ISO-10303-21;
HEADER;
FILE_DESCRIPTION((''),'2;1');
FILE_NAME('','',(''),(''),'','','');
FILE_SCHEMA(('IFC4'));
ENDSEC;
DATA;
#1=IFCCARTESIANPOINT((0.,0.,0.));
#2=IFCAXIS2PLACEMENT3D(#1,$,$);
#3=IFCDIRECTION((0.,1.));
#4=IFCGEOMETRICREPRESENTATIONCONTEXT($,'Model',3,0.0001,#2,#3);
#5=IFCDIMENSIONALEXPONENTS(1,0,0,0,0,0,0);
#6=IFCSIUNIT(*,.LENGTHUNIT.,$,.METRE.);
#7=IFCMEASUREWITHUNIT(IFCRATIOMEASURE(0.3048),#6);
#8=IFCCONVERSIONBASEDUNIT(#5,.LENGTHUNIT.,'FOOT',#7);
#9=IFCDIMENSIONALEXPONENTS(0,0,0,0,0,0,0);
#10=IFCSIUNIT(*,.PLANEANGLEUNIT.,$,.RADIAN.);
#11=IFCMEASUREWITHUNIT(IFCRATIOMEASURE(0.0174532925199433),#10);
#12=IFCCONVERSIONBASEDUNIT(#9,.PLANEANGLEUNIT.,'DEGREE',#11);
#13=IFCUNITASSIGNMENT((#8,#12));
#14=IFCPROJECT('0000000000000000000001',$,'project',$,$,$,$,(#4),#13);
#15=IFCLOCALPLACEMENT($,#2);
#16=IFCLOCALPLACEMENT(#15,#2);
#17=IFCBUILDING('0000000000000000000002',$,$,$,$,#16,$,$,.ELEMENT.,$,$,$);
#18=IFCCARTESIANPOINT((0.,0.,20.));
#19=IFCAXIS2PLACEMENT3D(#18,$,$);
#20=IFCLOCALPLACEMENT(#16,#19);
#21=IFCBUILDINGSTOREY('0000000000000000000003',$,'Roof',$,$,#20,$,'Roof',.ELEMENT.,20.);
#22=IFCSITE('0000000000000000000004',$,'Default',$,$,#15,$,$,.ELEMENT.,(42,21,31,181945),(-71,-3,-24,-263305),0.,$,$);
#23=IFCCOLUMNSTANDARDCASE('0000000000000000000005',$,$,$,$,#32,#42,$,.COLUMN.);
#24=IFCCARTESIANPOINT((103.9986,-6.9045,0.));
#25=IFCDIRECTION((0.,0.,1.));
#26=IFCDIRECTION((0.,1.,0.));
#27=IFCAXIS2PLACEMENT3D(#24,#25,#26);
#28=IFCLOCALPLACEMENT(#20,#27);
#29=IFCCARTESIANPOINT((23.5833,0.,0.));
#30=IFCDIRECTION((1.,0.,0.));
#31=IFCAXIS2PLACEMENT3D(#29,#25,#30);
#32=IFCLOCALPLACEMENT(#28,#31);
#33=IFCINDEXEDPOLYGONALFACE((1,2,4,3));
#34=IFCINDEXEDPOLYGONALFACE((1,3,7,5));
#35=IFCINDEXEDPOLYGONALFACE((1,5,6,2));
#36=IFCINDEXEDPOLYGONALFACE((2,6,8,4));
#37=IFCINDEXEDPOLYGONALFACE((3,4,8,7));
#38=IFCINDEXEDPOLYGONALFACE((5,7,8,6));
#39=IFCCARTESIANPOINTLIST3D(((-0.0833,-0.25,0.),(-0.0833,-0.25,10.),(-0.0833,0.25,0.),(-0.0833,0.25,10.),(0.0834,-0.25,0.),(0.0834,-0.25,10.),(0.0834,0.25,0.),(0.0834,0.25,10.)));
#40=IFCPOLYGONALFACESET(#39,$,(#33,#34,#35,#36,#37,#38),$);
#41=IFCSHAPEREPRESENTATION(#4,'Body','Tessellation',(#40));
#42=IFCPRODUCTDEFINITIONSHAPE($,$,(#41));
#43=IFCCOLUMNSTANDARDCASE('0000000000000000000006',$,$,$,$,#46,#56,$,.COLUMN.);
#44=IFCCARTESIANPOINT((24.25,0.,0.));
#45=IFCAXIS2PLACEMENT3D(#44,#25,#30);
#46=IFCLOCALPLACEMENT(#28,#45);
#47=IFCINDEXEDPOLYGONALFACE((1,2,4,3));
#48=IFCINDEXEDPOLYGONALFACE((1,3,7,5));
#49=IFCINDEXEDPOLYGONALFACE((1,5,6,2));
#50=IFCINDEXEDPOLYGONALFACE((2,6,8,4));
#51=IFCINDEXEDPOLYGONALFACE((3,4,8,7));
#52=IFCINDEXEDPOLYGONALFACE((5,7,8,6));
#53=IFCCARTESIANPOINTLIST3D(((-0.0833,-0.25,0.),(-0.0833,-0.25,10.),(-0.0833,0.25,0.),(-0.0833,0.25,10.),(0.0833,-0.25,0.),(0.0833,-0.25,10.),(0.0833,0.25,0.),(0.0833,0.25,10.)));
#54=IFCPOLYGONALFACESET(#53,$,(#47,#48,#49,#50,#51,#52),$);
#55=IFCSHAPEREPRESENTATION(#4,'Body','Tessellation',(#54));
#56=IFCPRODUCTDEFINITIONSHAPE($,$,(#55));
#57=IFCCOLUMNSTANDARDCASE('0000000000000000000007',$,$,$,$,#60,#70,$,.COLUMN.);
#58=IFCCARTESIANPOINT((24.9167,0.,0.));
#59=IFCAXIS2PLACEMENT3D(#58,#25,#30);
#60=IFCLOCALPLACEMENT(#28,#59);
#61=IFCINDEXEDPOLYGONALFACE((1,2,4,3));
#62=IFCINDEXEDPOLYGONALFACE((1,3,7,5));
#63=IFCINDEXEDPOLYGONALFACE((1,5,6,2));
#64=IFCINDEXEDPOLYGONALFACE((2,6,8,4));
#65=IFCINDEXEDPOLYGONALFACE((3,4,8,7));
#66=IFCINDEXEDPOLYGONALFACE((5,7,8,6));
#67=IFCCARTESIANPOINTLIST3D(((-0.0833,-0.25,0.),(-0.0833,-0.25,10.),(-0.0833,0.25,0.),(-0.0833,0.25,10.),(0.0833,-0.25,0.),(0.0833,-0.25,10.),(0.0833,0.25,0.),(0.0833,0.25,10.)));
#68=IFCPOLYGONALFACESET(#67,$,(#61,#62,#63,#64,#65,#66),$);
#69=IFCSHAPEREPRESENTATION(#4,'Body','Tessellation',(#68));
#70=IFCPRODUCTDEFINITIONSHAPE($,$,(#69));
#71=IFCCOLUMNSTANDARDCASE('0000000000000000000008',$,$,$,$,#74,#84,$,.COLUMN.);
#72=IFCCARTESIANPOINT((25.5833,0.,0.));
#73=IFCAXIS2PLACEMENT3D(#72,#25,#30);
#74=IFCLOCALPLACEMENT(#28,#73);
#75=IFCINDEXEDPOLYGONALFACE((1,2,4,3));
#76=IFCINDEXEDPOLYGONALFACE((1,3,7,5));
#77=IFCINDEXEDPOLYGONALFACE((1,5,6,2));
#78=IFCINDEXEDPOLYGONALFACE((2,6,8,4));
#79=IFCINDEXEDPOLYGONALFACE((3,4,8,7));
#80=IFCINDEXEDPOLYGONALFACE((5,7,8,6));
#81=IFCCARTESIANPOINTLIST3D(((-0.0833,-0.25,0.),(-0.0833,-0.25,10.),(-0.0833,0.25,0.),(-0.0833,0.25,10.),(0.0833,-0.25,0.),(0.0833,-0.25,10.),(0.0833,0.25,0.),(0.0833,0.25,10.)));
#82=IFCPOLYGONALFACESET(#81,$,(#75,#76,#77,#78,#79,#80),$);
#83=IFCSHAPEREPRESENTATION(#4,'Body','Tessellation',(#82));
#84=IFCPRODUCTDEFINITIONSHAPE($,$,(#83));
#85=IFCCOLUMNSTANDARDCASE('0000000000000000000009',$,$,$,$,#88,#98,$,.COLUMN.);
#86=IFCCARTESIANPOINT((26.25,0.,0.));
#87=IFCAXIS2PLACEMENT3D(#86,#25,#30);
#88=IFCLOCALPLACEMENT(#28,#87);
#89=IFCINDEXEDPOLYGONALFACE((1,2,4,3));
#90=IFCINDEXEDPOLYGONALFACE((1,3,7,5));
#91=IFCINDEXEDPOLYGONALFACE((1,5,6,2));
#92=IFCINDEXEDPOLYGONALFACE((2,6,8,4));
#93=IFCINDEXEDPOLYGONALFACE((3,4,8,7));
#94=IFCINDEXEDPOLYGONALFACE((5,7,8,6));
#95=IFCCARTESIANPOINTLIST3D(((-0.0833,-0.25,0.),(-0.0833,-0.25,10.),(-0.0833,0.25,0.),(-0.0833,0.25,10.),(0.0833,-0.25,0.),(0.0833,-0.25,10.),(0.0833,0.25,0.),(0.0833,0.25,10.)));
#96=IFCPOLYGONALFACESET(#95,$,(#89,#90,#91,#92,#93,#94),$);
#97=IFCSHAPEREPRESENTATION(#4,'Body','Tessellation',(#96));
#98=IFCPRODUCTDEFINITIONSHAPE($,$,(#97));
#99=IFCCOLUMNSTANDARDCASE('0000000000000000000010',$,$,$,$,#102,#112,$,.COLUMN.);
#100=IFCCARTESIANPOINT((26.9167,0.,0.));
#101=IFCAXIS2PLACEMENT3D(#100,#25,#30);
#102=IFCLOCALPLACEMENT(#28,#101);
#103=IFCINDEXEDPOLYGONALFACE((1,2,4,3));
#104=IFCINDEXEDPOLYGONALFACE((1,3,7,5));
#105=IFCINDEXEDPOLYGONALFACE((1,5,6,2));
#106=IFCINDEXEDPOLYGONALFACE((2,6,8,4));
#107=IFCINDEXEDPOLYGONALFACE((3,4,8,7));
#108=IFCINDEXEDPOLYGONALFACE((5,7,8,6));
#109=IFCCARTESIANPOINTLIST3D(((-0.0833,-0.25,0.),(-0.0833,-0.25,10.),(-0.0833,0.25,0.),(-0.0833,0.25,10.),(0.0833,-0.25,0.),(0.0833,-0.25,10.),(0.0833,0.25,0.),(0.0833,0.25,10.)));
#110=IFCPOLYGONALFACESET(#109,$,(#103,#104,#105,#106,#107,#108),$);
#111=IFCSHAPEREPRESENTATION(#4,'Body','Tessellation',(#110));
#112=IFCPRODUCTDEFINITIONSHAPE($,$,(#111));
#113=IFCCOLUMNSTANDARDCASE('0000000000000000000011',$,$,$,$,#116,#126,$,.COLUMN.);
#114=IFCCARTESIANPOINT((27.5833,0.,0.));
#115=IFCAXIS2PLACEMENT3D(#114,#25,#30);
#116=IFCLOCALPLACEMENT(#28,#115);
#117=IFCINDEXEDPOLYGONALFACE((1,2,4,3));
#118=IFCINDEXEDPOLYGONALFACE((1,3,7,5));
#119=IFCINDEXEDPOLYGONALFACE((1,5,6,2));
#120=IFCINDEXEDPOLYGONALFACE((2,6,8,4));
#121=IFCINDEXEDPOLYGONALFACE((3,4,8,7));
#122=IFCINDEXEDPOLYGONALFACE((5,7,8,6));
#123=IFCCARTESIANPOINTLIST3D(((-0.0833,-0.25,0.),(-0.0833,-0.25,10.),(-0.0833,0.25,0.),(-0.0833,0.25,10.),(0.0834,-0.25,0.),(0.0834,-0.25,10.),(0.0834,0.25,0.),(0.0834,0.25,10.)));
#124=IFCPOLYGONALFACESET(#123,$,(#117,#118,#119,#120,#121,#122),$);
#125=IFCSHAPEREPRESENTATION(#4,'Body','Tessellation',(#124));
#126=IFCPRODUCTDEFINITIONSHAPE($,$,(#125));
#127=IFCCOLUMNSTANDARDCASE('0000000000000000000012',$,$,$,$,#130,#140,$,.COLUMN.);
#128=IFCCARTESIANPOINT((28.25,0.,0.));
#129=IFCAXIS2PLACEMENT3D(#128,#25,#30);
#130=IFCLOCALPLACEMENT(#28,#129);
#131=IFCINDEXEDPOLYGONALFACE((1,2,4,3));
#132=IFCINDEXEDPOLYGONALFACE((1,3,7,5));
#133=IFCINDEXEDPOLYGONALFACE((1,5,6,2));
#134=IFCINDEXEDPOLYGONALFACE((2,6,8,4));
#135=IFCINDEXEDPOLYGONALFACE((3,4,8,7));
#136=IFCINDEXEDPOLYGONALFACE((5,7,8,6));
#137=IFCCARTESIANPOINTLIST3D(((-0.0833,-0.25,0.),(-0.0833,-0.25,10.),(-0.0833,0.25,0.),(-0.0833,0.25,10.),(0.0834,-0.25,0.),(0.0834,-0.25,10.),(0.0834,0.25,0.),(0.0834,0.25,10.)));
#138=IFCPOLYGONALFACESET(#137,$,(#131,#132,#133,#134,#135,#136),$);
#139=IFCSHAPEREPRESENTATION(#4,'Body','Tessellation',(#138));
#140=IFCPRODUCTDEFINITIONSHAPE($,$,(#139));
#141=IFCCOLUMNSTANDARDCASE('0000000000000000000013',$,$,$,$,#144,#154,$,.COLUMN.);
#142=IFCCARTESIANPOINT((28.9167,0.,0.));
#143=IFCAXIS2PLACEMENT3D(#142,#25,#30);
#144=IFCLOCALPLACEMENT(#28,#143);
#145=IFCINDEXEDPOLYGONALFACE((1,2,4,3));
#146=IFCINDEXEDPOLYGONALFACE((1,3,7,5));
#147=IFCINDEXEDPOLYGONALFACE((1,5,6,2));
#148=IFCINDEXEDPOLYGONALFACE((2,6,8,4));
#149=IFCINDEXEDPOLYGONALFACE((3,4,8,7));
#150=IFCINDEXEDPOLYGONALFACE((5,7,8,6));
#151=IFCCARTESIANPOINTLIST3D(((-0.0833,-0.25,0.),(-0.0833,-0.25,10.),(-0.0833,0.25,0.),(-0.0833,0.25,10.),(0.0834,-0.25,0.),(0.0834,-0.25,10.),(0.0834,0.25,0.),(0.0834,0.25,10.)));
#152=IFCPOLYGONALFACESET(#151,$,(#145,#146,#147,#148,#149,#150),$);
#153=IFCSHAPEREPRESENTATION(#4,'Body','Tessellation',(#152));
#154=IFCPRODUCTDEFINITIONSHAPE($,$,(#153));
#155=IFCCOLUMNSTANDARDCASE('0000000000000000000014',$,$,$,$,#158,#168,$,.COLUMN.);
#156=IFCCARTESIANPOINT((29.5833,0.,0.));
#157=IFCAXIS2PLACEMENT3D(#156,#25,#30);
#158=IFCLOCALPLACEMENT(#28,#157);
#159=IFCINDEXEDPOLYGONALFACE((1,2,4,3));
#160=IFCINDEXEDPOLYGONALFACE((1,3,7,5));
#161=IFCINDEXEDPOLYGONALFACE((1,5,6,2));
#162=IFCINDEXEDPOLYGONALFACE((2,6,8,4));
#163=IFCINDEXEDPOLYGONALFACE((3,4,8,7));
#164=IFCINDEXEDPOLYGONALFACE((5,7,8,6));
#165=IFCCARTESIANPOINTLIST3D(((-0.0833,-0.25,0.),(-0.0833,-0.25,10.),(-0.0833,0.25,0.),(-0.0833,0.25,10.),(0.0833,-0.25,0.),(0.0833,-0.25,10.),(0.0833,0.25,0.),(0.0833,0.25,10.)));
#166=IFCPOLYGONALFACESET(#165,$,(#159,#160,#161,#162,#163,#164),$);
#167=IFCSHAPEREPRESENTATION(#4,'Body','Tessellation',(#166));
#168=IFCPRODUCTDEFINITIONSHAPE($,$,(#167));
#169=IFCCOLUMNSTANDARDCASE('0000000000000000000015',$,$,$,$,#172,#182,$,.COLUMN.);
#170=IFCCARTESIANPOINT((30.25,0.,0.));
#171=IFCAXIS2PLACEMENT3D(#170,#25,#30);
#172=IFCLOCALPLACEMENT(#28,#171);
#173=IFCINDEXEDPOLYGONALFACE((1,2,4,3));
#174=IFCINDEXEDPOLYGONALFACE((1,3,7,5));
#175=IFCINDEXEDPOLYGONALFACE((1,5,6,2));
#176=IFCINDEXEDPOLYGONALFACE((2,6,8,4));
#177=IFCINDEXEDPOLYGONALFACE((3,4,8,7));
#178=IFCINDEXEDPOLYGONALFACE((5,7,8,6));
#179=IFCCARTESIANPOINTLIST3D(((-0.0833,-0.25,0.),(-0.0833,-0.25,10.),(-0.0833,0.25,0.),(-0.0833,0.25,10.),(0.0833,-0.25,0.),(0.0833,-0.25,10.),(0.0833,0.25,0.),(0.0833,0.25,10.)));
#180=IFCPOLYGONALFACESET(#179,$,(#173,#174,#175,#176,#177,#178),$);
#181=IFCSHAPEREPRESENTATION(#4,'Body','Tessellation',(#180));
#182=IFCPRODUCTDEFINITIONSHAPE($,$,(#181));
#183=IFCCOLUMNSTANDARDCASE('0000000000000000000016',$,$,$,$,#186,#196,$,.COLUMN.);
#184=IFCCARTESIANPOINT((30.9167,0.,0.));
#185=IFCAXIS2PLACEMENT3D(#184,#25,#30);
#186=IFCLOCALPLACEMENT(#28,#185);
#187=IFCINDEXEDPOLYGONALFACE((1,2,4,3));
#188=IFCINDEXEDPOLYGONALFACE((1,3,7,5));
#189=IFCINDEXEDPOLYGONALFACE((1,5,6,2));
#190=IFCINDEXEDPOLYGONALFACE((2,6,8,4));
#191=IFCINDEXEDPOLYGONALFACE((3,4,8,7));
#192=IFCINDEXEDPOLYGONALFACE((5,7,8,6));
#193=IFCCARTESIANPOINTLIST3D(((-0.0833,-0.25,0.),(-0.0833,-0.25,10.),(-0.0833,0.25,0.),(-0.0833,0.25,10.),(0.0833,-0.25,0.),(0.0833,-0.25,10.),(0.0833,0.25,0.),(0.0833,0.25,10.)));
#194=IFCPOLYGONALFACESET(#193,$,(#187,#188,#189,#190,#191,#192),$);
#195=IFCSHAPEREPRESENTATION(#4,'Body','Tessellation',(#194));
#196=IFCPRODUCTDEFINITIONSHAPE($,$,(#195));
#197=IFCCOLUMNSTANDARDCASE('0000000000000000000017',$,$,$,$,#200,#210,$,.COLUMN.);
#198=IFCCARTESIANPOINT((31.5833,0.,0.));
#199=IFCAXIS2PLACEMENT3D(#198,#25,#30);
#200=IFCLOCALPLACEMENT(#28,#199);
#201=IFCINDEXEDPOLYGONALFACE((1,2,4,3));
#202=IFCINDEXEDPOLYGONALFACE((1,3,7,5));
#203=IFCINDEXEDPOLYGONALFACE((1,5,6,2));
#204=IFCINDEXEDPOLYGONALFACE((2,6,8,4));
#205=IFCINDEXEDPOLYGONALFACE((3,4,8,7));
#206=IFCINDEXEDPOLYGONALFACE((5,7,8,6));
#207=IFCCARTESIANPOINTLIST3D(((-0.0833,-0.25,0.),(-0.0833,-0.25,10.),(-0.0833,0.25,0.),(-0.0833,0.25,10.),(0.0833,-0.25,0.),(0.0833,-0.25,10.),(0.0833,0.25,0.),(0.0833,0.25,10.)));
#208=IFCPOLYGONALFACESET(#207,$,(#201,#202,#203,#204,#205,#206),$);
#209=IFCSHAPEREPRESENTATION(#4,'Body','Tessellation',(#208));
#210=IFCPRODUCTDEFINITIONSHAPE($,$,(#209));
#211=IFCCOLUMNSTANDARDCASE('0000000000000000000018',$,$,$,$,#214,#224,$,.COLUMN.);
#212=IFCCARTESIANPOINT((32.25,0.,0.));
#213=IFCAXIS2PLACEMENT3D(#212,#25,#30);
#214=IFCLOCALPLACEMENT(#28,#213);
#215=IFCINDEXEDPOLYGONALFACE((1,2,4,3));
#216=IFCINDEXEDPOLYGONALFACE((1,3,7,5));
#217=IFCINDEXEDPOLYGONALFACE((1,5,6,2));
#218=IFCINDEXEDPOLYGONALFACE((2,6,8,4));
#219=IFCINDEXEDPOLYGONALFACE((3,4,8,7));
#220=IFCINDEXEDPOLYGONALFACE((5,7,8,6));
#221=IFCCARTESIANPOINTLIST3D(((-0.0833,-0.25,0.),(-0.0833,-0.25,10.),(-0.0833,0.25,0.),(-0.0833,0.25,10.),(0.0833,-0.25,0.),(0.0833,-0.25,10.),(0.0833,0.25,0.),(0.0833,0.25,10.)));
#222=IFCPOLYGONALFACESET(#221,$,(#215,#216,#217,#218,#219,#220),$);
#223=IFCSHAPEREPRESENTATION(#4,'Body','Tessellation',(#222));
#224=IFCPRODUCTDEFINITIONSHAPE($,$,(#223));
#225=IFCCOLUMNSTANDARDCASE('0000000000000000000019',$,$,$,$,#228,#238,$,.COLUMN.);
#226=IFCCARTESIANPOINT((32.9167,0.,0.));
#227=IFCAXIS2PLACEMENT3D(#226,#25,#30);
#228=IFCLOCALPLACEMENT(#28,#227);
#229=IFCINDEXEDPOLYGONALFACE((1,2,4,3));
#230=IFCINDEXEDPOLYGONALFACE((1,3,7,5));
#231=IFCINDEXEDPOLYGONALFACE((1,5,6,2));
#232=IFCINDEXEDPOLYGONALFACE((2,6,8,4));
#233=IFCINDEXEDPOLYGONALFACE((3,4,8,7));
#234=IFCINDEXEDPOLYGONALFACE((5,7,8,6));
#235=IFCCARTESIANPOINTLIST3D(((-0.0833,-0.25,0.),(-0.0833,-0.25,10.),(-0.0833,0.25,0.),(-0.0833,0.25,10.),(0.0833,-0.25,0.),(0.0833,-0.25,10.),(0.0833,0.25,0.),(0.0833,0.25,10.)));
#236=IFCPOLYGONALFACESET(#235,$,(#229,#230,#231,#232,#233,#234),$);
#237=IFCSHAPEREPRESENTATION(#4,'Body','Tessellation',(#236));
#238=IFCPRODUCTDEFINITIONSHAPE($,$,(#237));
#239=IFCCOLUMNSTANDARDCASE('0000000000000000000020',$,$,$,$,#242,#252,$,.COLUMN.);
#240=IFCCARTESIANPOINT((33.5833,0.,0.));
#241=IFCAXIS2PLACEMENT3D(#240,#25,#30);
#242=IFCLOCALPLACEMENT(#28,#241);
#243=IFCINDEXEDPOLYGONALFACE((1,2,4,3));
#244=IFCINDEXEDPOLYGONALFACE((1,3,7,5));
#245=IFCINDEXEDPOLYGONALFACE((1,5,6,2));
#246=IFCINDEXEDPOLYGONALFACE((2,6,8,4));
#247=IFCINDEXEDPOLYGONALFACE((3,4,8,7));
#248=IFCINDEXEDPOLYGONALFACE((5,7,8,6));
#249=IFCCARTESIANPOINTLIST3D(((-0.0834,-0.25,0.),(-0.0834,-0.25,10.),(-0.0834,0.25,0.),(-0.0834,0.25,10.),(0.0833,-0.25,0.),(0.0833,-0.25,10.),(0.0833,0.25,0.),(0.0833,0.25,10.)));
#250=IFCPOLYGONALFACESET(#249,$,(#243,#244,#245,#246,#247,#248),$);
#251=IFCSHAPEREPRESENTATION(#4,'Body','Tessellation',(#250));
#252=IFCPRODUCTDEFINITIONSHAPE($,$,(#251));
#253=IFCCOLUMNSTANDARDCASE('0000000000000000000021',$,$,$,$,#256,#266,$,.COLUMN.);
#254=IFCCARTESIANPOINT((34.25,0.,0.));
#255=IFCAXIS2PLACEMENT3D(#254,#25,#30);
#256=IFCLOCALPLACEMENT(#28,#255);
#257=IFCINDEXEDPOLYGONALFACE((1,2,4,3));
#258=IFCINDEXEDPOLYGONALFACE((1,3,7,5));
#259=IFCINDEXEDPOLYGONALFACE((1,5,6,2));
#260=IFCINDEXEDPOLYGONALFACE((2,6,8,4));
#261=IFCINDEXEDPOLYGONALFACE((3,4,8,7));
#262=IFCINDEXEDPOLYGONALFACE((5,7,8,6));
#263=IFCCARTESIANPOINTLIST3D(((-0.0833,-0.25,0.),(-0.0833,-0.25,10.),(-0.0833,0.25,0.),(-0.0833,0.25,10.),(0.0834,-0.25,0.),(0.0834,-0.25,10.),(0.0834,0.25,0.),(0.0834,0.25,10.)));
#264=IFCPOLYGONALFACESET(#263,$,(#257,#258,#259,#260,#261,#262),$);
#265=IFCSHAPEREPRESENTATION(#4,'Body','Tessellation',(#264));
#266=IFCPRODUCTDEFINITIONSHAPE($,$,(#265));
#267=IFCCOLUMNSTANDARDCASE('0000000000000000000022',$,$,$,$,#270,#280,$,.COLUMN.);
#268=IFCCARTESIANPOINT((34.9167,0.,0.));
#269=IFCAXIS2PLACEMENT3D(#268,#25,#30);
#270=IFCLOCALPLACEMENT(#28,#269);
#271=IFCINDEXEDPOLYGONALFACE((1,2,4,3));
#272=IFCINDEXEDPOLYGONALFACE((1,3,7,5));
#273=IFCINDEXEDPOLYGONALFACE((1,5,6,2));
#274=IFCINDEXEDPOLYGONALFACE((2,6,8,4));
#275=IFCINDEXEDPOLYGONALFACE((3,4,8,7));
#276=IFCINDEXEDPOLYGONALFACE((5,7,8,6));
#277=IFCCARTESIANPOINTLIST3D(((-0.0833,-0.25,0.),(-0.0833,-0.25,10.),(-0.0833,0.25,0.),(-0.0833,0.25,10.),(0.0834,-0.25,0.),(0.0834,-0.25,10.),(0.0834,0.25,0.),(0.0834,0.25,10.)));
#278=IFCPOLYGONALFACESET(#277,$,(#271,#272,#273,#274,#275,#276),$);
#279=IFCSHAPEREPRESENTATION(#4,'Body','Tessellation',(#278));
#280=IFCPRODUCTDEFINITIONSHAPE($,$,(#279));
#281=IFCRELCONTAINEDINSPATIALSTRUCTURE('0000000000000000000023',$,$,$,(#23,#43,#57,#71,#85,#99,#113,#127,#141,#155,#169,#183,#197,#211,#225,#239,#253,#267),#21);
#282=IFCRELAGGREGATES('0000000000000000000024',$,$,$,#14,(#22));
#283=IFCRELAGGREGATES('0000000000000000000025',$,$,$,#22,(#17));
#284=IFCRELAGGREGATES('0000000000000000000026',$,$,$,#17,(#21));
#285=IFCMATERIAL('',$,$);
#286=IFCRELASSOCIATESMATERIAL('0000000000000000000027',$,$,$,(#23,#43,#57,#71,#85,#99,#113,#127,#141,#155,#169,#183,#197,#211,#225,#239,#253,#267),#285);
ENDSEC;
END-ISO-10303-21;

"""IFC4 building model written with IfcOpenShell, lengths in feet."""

from ifc_helpers import new_model, entity, si_unit, converted_unit, direction, frame, origin, place, context, project, spatial, rectangle, extrude, material, element, save


model = new_model("IFC4")

# Units and contexts
model_context = context("Model", 3, precision=0.0001, world=origin(), true_north=direction((0.0, 1.0)))
ifc_project = project(units=[converted_unit("LENGTHUNIT", "FOOT", entity("IfcRatioMeasure", 0.3048), si_unit("LENGTHUNIT", "METRE"), dimensions=[1, 0, 0, 0, 0, 0, 0]), converted_unit("PLANEANGLEUNIT", "DEGREE", entity("IfcRatioMeasure", 0.0174532925199433), si_unit("PLANEANGLEUNIT", "RADIAN"), dimensions=[0, 0, 0, 0, 0, 0, 0])], contexts=[model_context])

# Site, building, storey
site_placement = place(None, origin())
site = spatial("IfcSite", under=ifc_project, at=site_placement, Name="Default", CompositionType="ELEMENT", RefLatitude=(42, 21, 31, 181945), RefLongitude=(-71, -3, -24, -263305), RefElevation=0.0)
building_placement = place(site_placement, origin())
building = spatial("IfcBuilding", under=site, at=building_placement, CompositionType="ELEMENT")
storey_placement = place(building_placement, frame((0.0, 0.0, 20.0)))
storey = spatial("IfcBuildingStorey", under=building, at=storey_placement, Name="Roof", LongName="Roof", CompositionType="ELEMENT", Elevation=20.0)

# Columns
ifc_material_1 = material(Name="")
placement_1 = place(storey_placement, frame((103.9986, -6.9045, 0.0), z_axis=(0.0, 0.0, 1.0), x_axis=(0.0, 1.0, 0.0)))
for number, where, z_axis, x_axis in (
    (1, (23.5833, 0.0, 0.0), (0.0, 0.0, 1.0), (1.0, 0.0, 0.0)),
    (2, (24.25, 0.0, 0.0), (0.0, 0.0, 1.0), (1.0, 0.0, 0.0)),
    (3, (24.9167, 0.0, 0.0), (0.0, 0.0, 1.0), (1.0, 0.0, 0.0)),
    (4, (25.5833, 0.0, 0.0), (0.0, 0.0, 1.0), (1.0, 0.0, 0.0)),
    (5, (26.25, 0.0, 0.0), (0.0, 0.0, 1.0), (1.0, 0.0, 0.0)),
    (6, (26.9167, 0.0, 0.0), (0.0, 0.0, 1.0), (1.0, 0.0, 0.0)),
    (7, (27.5833, 0.0, 0.0), (0.0, 0.0, 1.0), (1.0, 0.0, 0.0)),
    (8, (28.25, 0.0, 0.0), (0.0, 0.0, 1.0), (1.0, 0.0, 0.0)),
    (9, (28.9167, 0.0, 0.0), (0.0, 0.0, 1.0), (1.0, 0.0, 0.0)),
    (10, (29.5833, 0.0, 0.0), (0.0, 0.0, 1.0), (1.0, 0.0, 0.0)),
    (11, (30.25, 0.0, 0.0), (0.0, 0.0, 1.0), (1.0, 0.0, 0.0)),
    (12, (30.9167, 0.0, 0.0), (0.0, 0.0, 1.0), (1.0, 0.0, 0.0)),
    (13, (31.5833, 0.0, 0.0), (0.0, 0.0, 1.0), (1.0, 0.0, 0.0)),
    (14, (32.25, 0.0, 0.0), (0.0, 0.0, 1.0), (1.0, 0.0, 0.0)),
    (15, (32.9167, 0.0, 0.0), (0.0, 0.0, 1.0), (1.0, 0.0, 0.0)),
    (16, (33.5833, 0.0, 0.0), (0.0, 0.0, 1.0), (1.0, 0.0, 0.0)),
    (17, (34.25, 0.0, 0.0), (0.0, 0.0, 1.0), (1.0, 0.0, 0.0)),
    (18, (34.9167, 0.0, 0.0), (0.0, 0.0, 1.0), (1.0, 0.0, 0.0)),
):
    element("IfcColumnStandardCase", number, at=place(placement_1, frame(where, z_axis=z_axis, x_axis=x_axis)), inside=storey, material=ifc_material_1, PredefinedType="COLUMN", context=model_context, shape_type="SweptSolid", body=[
        extrude(rectangle(XDim=0.1667, YDim=0.5), origin(), (0.0, 0.0, 1.0), 10.0),
    ])

save(model, "model.ifc")
